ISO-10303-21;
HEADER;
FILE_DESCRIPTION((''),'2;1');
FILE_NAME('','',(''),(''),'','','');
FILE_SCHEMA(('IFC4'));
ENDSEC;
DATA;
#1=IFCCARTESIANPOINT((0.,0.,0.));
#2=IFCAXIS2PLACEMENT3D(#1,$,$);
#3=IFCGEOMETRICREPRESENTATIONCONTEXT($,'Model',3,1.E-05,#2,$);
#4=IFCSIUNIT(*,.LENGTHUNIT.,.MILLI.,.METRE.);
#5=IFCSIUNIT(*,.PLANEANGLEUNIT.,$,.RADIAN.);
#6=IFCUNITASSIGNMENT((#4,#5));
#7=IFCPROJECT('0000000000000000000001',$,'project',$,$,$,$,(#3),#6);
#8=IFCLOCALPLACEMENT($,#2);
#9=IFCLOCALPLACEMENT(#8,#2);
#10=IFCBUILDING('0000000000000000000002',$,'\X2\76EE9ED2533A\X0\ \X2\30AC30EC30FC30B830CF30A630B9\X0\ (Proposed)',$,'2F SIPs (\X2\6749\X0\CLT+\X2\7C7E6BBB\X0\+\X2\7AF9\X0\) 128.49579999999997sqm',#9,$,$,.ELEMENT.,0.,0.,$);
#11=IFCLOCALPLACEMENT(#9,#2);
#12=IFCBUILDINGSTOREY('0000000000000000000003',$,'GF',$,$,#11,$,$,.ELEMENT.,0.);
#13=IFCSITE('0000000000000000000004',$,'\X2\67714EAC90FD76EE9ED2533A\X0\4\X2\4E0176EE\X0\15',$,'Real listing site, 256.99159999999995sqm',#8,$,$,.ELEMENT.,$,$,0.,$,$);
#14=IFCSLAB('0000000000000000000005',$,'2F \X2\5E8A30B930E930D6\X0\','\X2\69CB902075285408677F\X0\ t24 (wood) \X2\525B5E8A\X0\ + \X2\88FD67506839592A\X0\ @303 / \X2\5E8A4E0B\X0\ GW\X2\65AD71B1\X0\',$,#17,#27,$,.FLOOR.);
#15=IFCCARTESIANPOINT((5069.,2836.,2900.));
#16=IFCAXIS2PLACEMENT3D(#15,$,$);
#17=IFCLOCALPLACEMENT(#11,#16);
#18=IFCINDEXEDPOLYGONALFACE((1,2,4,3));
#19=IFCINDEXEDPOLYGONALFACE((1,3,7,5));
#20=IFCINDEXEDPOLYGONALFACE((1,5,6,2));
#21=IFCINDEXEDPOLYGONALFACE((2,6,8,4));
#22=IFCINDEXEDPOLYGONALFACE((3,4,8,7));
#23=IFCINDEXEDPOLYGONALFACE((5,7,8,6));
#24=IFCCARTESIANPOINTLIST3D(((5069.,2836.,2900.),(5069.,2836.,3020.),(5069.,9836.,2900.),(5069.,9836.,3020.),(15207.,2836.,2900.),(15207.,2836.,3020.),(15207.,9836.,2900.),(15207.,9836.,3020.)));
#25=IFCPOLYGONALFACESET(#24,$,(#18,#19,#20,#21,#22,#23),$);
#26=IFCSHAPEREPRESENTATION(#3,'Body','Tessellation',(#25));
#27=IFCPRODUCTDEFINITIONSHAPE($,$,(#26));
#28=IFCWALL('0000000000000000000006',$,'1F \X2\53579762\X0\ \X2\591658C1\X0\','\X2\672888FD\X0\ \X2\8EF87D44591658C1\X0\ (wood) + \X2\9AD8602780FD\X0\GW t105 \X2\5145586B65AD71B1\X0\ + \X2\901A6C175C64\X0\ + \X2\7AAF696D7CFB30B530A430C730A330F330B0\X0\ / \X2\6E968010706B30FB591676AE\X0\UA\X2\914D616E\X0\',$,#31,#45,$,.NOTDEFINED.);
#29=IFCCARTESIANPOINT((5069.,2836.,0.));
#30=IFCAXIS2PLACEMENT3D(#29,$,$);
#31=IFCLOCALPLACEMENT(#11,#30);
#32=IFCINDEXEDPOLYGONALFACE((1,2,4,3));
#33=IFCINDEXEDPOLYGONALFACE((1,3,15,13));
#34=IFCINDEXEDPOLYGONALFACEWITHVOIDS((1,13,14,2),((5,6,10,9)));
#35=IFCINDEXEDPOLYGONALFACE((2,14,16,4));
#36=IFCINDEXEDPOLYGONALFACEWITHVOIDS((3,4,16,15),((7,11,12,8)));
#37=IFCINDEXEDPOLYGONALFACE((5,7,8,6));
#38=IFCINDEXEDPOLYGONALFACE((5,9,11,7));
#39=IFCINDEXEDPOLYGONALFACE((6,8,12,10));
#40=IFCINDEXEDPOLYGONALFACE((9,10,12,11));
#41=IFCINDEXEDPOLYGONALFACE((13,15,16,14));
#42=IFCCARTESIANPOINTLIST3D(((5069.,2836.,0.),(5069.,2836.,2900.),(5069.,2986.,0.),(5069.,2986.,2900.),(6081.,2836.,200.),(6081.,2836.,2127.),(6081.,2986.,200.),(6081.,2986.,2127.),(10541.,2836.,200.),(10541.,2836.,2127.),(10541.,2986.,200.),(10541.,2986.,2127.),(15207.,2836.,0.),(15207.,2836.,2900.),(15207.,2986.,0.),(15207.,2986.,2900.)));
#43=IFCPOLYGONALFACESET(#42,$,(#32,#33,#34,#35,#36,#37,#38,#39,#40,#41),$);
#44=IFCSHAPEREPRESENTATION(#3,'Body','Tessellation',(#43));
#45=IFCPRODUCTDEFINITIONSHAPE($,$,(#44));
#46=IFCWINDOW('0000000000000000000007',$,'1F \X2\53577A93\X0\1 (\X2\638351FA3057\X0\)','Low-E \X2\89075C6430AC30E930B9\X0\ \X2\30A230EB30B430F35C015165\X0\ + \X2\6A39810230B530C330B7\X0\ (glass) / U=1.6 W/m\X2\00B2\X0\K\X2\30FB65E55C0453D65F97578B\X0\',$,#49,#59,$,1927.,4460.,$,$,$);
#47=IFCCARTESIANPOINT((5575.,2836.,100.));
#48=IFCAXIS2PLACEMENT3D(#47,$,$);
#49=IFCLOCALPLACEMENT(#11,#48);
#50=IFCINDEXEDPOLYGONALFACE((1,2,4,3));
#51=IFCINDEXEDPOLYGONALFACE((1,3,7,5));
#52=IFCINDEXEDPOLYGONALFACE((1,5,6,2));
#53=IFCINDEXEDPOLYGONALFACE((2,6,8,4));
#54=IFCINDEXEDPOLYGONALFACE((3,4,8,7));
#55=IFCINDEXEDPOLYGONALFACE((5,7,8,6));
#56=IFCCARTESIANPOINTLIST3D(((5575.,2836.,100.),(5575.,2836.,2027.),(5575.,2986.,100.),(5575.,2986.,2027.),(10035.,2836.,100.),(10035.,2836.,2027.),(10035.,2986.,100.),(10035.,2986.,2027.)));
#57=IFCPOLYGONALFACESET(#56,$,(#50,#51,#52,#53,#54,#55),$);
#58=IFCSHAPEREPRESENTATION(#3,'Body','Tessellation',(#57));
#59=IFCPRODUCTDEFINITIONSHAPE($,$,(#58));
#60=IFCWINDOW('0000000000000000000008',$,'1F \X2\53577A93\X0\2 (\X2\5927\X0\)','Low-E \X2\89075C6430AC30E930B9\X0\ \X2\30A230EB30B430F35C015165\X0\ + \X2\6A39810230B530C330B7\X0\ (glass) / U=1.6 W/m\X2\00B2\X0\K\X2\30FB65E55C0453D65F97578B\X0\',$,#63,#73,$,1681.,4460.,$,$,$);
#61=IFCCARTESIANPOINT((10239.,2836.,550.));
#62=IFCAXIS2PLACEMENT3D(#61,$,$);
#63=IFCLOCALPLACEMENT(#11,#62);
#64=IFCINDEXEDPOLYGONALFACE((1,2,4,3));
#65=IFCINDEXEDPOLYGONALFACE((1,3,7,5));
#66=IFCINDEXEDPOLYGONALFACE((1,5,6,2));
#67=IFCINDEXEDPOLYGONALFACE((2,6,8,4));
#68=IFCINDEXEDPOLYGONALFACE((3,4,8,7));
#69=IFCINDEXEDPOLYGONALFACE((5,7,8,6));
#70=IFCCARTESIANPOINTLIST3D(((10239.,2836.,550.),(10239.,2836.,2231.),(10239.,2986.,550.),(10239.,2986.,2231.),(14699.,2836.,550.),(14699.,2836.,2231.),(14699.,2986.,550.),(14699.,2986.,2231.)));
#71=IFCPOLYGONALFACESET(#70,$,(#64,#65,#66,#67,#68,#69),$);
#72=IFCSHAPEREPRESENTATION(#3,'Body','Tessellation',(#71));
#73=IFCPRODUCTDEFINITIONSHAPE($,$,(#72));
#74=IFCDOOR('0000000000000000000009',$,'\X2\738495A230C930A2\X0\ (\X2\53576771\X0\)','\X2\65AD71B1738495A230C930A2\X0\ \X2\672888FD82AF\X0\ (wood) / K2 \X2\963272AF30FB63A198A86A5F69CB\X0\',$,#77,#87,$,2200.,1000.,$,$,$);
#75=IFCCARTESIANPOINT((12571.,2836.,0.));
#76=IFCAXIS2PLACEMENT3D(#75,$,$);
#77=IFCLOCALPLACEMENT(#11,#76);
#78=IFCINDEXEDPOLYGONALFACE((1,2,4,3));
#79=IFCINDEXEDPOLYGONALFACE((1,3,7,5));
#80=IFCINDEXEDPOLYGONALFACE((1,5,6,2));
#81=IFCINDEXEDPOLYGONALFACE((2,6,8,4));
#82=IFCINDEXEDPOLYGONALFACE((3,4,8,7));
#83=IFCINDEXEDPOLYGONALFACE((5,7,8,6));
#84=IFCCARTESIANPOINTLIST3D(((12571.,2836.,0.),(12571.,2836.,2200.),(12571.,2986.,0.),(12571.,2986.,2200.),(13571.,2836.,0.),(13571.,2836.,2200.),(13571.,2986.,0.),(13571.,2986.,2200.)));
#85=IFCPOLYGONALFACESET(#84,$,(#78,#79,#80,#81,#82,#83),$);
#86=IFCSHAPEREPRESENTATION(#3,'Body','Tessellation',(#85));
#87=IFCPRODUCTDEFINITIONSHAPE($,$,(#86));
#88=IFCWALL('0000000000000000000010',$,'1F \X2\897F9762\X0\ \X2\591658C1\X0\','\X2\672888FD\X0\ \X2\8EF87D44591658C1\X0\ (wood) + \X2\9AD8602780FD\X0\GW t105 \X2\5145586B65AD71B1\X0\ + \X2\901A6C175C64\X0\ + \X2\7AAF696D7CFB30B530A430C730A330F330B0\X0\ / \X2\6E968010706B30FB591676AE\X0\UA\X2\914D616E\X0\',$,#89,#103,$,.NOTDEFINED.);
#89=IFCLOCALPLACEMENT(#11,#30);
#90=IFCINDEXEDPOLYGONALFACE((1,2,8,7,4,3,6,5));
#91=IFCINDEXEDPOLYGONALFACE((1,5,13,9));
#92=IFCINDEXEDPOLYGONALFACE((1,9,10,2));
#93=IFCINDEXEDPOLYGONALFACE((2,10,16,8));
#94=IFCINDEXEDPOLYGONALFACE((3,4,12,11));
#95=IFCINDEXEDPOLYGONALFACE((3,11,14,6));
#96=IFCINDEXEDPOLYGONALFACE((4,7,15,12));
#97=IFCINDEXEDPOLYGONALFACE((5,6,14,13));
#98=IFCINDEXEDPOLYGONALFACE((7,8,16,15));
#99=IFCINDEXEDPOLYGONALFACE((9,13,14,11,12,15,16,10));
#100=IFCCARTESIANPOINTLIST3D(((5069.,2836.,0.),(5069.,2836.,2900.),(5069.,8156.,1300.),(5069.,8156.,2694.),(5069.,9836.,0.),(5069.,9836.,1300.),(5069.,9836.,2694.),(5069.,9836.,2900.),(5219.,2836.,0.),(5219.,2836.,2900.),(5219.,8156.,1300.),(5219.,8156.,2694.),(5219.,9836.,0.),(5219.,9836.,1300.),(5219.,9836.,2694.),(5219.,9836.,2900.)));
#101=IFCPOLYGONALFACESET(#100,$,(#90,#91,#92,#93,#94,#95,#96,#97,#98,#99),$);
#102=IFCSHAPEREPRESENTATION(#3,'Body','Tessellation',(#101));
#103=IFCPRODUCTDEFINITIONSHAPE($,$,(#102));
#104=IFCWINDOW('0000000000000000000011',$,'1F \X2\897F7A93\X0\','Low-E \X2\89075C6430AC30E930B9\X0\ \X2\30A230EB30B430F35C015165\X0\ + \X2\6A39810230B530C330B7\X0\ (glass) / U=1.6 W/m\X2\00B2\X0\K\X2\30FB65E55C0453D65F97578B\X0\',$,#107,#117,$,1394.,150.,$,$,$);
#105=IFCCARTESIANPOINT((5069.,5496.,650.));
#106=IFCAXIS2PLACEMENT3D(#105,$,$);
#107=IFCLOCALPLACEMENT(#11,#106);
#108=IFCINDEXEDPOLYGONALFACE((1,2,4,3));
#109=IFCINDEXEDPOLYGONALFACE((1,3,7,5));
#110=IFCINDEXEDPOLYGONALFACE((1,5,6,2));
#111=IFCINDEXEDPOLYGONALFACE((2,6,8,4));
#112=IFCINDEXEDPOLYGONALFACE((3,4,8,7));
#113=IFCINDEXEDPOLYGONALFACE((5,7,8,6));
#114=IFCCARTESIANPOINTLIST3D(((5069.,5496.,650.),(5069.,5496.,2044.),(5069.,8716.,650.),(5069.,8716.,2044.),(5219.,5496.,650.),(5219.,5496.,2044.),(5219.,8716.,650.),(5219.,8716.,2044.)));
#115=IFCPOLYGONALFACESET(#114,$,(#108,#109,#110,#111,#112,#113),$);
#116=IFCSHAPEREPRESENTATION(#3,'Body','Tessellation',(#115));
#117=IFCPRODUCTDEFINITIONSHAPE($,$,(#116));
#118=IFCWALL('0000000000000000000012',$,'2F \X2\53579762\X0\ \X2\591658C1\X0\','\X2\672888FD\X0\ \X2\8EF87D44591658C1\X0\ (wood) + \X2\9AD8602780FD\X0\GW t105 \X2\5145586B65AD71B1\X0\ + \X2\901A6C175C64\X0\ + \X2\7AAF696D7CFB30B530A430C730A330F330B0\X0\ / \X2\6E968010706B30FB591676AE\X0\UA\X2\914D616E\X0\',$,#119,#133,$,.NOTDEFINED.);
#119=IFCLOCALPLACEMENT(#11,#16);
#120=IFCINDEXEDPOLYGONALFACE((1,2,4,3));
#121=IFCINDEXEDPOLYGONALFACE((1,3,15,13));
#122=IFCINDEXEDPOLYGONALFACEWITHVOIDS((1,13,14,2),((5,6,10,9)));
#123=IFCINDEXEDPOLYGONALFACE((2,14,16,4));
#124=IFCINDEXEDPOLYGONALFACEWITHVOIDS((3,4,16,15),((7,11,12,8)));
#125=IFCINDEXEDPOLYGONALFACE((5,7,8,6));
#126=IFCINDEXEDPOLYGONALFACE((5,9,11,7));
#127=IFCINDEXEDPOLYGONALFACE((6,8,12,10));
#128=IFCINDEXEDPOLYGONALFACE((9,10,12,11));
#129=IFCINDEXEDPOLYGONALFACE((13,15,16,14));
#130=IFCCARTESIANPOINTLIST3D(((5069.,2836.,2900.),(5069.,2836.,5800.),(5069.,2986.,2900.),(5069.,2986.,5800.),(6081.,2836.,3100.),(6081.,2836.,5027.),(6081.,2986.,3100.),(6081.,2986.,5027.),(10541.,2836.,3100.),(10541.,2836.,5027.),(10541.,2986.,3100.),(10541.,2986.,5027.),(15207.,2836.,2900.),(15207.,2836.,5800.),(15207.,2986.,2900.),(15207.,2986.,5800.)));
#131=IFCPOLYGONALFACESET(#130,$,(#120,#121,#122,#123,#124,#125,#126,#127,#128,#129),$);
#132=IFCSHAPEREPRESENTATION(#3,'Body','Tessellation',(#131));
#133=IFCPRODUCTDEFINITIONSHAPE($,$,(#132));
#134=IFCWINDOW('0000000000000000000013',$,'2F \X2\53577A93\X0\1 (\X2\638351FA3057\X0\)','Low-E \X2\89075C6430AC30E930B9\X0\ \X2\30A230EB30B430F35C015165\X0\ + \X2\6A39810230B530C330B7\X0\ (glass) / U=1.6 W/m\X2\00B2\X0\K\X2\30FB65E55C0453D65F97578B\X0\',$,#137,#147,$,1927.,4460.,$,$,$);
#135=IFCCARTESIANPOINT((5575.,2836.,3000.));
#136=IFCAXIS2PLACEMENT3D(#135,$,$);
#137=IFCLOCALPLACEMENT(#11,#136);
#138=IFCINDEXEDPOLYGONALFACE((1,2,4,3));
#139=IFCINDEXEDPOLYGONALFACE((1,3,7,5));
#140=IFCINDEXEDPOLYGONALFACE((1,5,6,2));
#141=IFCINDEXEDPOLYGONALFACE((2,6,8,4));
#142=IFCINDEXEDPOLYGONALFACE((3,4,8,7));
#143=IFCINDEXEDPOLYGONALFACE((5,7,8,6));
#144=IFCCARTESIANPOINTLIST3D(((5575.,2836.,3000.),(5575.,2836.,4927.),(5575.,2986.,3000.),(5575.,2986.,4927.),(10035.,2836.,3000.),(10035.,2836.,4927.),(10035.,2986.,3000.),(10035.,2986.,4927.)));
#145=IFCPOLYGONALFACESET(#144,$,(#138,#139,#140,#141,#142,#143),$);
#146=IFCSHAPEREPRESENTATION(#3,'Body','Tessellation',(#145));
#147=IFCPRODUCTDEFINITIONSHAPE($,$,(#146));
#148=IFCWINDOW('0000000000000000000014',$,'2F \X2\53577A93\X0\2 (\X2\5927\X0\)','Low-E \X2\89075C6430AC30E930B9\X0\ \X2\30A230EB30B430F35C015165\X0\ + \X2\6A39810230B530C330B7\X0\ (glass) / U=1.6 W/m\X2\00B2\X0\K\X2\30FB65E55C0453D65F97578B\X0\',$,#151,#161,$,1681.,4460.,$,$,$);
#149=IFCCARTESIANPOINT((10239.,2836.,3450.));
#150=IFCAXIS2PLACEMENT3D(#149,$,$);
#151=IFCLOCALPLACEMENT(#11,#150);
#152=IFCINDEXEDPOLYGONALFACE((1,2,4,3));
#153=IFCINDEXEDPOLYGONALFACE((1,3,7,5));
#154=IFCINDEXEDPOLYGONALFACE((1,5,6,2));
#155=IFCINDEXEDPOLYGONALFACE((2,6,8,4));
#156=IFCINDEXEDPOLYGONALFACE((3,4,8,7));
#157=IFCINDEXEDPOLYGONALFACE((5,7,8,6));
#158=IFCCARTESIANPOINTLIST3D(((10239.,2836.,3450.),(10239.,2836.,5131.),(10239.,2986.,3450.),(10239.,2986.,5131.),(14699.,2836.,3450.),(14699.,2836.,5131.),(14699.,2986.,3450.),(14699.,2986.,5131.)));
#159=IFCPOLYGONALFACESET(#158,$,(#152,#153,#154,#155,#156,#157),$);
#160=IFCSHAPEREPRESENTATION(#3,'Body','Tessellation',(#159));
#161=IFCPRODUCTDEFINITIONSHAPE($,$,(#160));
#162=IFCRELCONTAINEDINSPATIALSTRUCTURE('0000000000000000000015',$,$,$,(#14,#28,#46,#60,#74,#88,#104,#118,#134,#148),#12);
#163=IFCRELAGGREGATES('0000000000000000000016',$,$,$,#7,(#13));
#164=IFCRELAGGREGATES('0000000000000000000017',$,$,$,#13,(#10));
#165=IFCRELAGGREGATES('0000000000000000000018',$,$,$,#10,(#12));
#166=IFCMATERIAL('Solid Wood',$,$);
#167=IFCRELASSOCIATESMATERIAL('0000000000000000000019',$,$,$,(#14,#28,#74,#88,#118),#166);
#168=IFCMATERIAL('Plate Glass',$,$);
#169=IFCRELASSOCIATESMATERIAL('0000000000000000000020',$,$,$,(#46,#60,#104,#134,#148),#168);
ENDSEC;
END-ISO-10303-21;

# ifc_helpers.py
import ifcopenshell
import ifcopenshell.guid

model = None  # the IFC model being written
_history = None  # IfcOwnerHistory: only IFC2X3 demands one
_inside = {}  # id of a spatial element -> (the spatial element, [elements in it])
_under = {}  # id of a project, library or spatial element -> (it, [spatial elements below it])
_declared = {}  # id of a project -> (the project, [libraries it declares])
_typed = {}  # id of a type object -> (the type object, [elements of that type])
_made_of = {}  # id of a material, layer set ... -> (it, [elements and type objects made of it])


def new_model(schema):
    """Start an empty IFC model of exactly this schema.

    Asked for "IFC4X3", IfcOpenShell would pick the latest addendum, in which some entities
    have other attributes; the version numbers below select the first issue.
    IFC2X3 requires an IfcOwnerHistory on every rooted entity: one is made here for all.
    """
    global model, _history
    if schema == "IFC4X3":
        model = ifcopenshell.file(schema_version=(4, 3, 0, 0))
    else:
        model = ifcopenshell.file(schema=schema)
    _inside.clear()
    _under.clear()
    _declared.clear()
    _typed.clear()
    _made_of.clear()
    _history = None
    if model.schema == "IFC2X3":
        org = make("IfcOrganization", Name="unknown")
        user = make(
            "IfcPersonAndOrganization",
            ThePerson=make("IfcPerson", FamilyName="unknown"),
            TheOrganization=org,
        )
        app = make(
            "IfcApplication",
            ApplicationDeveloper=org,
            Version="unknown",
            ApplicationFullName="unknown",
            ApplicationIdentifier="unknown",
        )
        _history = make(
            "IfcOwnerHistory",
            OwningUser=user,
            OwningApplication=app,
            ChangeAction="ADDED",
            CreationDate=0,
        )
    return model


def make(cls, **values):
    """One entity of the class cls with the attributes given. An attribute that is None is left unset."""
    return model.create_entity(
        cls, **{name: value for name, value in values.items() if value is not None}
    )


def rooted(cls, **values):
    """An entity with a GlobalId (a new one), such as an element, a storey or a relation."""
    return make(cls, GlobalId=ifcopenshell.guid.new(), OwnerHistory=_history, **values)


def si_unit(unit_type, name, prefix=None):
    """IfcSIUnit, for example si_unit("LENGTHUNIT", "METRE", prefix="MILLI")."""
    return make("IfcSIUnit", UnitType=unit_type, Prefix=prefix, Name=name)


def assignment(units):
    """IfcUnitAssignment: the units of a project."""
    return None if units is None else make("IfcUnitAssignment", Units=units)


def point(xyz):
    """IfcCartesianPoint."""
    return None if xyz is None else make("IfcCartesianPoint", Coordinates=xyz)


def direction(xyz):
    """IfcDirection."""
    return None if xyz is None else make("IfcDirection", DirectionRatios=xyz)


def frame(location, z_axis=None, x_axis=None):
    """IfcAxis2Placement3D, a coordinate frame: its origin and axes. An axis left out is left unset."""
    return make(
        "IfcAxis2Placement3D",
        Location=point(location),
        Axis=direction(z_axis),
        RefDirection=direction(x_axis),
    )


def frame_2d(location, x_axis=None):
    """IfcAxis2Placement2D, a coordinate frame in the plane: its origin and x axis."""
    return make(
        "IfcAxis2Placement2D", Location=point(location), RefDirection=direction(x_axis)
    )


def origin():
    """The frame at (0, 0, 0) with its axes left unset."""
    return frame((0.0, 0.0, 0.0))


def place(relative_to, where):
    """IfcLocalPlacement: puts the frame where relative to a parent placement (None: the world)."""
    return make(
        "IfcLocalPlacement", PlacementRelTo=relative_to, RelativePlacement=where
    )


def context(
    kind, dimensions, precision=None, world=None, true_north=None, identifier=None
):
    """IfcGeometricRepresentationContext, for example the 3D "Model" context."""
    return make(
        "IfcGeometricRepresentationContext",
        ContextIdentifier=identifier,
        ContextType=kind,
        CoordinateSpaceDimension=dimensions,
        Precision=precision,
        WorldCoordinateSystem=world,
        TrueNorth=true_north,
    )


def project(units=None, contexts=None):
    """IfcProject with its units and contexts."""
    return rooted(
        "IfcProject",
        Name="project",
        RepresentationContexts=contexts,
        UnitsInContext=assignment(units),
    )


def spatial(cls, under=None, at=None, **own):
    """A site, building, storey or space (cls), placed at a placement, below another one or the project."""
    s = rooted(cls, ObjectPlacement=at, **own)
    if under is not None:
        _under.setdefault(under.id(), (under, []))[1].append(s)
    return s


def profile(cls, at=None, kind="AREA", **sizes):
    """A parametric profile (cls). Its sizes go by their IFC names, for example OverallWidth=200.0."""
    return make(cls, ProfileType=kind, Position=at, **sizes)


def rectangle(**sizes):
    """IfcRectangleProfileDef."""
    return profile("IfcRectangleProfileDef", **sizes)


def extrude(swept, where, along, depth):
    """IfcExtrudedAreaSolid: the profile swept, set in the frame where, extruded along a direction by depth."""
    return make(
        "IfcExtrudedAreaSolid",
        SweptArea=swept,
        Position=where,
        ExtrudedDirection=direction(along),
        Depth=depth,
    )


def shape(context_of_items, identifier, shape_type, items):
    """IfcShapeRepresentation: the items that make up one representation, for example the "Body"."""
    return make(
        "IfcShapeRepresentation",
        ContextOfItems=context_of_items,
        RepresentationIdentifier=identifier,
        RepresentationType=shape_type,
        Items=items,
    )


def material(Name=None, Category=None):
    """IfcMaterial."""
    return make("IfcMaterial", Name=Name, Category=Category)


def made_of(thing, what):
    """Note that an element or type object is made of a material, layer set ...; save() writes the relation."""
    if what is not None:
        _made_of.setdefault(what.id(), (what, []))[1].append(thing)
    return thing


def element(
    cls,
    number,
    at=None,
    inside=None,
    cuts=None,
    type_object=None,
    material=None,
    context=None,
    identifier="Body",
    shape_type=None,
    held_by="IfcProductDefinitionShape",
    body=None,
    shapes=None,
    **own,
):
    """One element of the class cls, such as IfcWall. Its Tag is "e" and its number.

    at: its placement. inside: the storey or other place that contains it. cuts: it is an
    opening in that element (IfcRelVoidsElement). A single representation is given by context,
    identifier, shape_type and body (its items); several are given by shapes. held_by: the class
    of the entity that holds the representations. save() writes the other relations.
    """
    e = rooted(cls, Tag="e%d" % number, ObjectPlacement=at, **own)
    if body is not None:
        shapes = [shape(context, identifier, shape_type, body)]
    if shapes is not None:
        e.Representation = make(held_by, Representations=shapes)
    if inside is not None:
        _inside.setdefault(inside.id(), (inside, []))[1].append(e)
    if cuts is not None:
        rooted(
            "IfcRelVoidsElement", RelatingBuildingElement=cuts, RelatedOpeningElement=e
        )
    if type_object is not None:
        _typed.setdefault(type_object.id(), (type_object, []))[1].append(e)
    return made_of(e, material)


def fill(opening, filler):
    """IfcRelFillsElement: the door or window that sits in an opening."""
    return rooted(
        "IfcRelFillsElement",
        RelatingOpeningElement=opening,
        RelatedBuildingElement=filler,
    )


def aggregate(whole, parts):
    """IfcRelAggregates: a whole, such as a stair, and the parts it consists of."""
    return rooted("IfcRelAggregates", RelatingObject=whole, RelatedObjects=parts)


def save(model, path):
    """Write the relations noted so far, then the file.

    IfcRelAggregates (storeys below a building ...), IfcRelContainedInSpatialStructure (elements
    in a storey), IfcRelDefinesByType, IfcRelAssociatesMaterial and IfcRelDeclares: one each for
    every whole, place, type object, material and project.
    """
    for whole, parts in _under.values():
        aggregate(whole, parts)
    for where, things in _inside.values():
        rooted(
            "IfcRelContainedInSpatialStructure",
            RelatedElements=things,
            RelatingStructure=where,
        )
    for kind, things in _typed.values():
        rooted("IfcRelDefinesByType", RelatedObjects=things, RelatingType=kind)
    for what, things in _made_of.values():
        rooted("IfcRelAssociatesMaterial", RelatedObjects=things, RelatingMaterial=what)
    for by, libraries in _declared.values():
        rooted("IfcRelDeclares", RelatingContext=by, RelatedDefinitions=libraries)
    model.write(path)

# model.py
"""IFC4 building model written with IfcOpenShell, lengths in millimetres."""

from ifc_helpers import new_model, si_unit, frame, frame_2d, origin, place, context, project, spatial, rectangle, extrude, material, element, fill, save


model = new_model("IFC4")

# Units and contexts
model_context = context("Model", 3, precision=1e-05, world=origin())
ifc_project = project(units=[si_unit("LENGTHUNIT", "METRE", prefix="MILLI"), si_unit("PLANEANGLEUNIT", "RADIAN")], contexts=[model_context])

# Site, building, storey
site_placement = place(None, origin())
site = spatial("IfcSite", under=ifc_project, at=site_placement, Name="東京都目黒区4丁目15", ObjectType="Real listing site, 256.99159999999995sqm", CompositionType="ELEMENT", RefElevation=0.0)
building_placement = place(site_placement, origin())
building = spatial("IfcBuilding", under=site, at=building_placement, Name="目黒区 ガレージハウス (Proposed)", ObjectType="2F SIPs (杉CLT+籾殻+竹) 128.49579999999997sqm", CompositionType="ELEMENT", ElevationOfRefHeight=0.0, ElevationOfTerrain=0.0)
storey_placement = place(building_placement, origin())
storey = spatial("IfcBuildingStorey", under=building, at=storey_placement, Name="GF", CompositionType="ELEMENT", Elevation=0.0)

# Slab
ifc_material_1 = material(Name="Solid Wood")
slab_1_placement = place(storey_placement, frame((5069.0, 2836.0, 2900.0)))
element("IfcSlab", 1, at=slab_1_placement, inside=storey, material=ifc_material_1, Name="2F 床スラブ", Description="構造用合板 t24 (wood) 剛床 + 製材根太 @303 / 床下 GW断熱", PredefinedType="FLOOR", context=model_context, shape_type="SweptSolid", body=[
    extrude(rectangle(XDim=10138.0, YDim=7000.0, at=frame_2d((5069.0, 3500.0))), frame((5069.0, 2836.0, 2900.0)), (0.0, 0.0, 1.0), 120.0),
])

# Wall, openings, windows, door
wall_1_placement = place(storey_placement, frame((5069.0, 2836.0, 0.0)))
wall_1 = element("IfcWall", 2, at=wall_1_placement, inside=storey, material=ifc_material_1, Name="1F 南面 外壁", Description="木製 軸組外壁 (wood) + 高性能GW t105 充填断熱 + 通気層 + 窯業系サイディング / 準耐火・外皮UA配慮", PredefinedType="NOTDEFINED", context=model_context, shape_type="SweptSolid", body=[
    extrude(rectangle(XDim=10138.0, YDim=150.0, at=frame_2d((5069.0, 75.0))), frame((5069.0, 2836.0, 0.0)), (0.0, 0.0, 1.0), 2900.0),
])
opening_1_placement = place(storey_placement, frame((5575.0, 2836.0, 100.0)))
opening_1 = element("IfcOpeningElement", 3, at=opening_1_placement, cuts=wall_1, PredefinedType="NOTDEFINED", context=model_context, shape_type="SweptSolid", body=[
    extrude(rectangle(XDim=4460.0, YDim=150.0, at=frame_2d((2230.0, 75.0))), frame((5575.0, 2836.0, 100.0)), (0.0, 0.0, 1.0), 1927.0),
])
opening_2_placement = place(storey_placement, frame((10239.0, 2836.0, 550.0)))
opening_2 = element("IfcOpeningElement", 4, at=opening_2_placement, cuts=wall_1, PredefinedType="NOTDEFINED", context=model_context, shape_type="SweptSolid", body=[
    extrude(rectangle(XDim=4460.0, YDim=150.0, at=frame_2d((2230.0, 75.0))), frame((10239.0, 2836.0, 550.0)), (0.0, 0.0, 1.0), 1681.0),
])
opening_3_placement = place(storey_placement, frame((12571.0, 2836.0, 0.0)))
opening_3 = element("IfcOpeningElement", 5, at=opening_3_placement, cuts=wall_1, PredefinedType="NOTDEFINED", context=model_context, shape_type="SweptSolid", body=[
    extrude(rectangle(XDim=1000.0, YDim=150.0, at=frame_2d((500.0, 75.0))), frame((12571.0, 2836.0, 0.0)), (0.0, 0.0, 1.0), 2200.0),
])
ifc_material_2 = material(Name="Plate Glass")
window_1_placement = place(storey_placement, frame((5575.0, 2836.0, 100.0)))
window_1 = element("IfcWindow", 6, at=window_1_placement, inside=storey, material=ifc_material_2, Name="1F 南窓1 (掃出し)", Description="Low-E 複層ガラス アルゴン封入 + 樹脂サッシ (glass) / U=1.6 W/m²K・日射取得型", OverallHeight=1927.0, OverallWidth=4460.0, context=model_context, shape_type="SweptSolid", body=[
    extrude(rectangle(XDim=4460.0, YDim=150.0, at=frame_2d((2230.0, 75.0))), frame((5575.0, 2836.0, 100.0)), (0.0, 0.0, 1.0), 1927.0),
])
fill(opening_1, window_1)
window_2_placement = place(storey_placement, frame((10239.0, 2836.0, 550.0)))
window_2 = element("IfcWindow", 7, at=window_2_placement, inside=storey, material=ifc_material_2, Name="1F 南窓2 (大)", Description="Low-E 複層ガラス アルゴン封入 + 樹脂サッシ (glass) / U=1.6 W/m²K・日射取得型", OverallHeight=1681.0, OverallWidth=4460.0, context=model_context, shape_type="SweptSolid", body=[
    extrude(rectangle(XDim=4460.0, YDim=150.0, at=frame_2d((2230.0, 75.0))), frame((10239.0, 2836.0, 550.0)), (0.0, 0.0, 1.0), 1681.0),
])
fill(opening_2, window_2)
door_placement = place(storey_placement, frame((12571.0, 2836.0, 0.0)))
door = element("IfcDoor", 8, at=door_placement, inside=storey, material=ifc_material_1, Name="玄関ドア (南東)", Description="断熱玄関ドア 木製芯 (wood) / K2 防犯・採風機構", OverallHeight=2200.0, OverallWidth=1000.0, context=model_context, shape_type="SweptSolid", body=[
    extrude(rectangle(XDim=1000.0, YDim=150.0, at=frame_2d((500.0, 75.0))), frame((12571.0, 2836.0, 0.0)), (0.0, 0.0, 1.0), 2200.0),
])
fill(opening_3, door)

# Wall, opening, window
wall_2_placement = place(storey_placement, frame((5069.0, 2836.0, 0.0)))
wall_2 = element("IfcWall", 9, at=wall_2_placement, inside=storey, material=ifc_material_1, Name="1F 西面 外壁", Description="木製 軸組外壁 (wood) + 高性能GW t105 充填断熱 + 通気層 + 窯業系サイディング / 準耐火・外皮UA配慮", PredefinedType="NOTDEFINED", context=model_context, shape_type="SweptSolid", body=[
    extrude(rectangle(XDim=150.0, YDim=7000.0, at=frame_2d((75.0, 3500.0))), frame((5069.0, 2836.0, 0.0)), (0.0, 0.0, 1.0), 2900.0),
])
opening_4_placement = place(storey_placement, frame((5069.0, 5496.0, 650.0)))
opening_4 = element("IfcOpeningElement", 10, at=opening_4_placement, cuts=wall_2, PredefinedType="NOTDEFINED", context=model_context, shape_type="SweptSolid", body=[
    extrude(rectangle(XDim=150.0, YDim=3220.0, at=frame_2d((75.0, 1610.0))), frame((5069.0, 5496.0, 650.0)), (0.0, 0.0, 1.0), 1394.0),
])
window_3_placement = place(storey_placement, frame((5069.0, 5496.0, 650.0)))
window_3 = element("IfcWindow", 11, at=window_3_placement, inside=storey, material=ifc_material_2, Name="1F 西窓", Description="Low-E 複層ガラス アルゴン封入 + 樹脂サッシ (glass) / U=1.6 W/m²K・日射取得型", OverallHeight=1394.0, OverallWidth=150.0, context=model_context, shape_type="SweptSolid", body=[
    extrude(rectangle(XDim=150.0, YDim=3220.0, at=frame_2d((75.0, 1610.0))), frame((5069.0, 5496.0, 650.0)), (0.0, 0.0, 1.0), 1394.0),
])
fill(opening_4, window_3)

# Wall, openings, windows
wall_3_placement = place(storey_placement, frame((5069.0, 2836.0, 2900.0)))
wall_3 = element("IfcWall", 12, at=wall_3_placement, inside=storey, material=ifc_material_1, Name="2F 南面 外壁", Description="木製 軸組外壁 (wood) + 高性能GW t105 充填断熱 + 通気層 + 窯業系サイディング / 準耐火・外皮UA配慮", PredefinedType="NOTDEFINED", context=model_context, shape_type="SweptSolid", body=[
    extrude(rectangle(XDim=10138.0, YDim=150.0, at=frame_2d((5069.0, 75.0))), frame((5069.0, 2836.0, 2900.0)), (0.0, 0.0, 1.0), 2900.0),
])
opening_5_placement = place(storey_placement, frame((5575.0, 2836.0, 3000.0)))
opening_5 = element("IfcOpeningElement", 13, at=opening_5_placement, cuts=wall_3, PredefinedType="NOTDEFINED", context=model_context, shape_type="SweptSolid", body=[
    extrude(rectangle(XDim=4460.0, YDim=150.0, at=frame_2d((2230.0, 75.0))), frame((5575.0, 2836.0, 3000.0)), (0.0, 0.0, 1.0), 1927.0),
])
opening_6_placement = place(storey_placement, frame((10239.0, 2836.0, 3450.0)))
opening_6 = element("IfcOpeningElement", 14, at=opening_6_placement, cuts=wall_3, PredefinedType="NOTDEFINED", context=model_context, shape_type="SweptSolid", body=[
    extrude(rectangle(XDim=4460.0, YDim=150.0, at=frame_2d((2230.0, 75.0))), frame((10239.0, 2836.0, 3450.0)), (0.0, 0.0, 1.0), 1681.0),
])
window_4_placement = place(storey_placement, frame((5575.0, 2836.0, 3000.0)))
window_4 = element("IfcWindow", 15, at=window_4_placement, inside=storey, material=ifc_material_2, Name="2F 南窓1 (掃出し)", Description="Low-E 複層ガラス アルゴン封入 + 樹脂サッシ (glass) / U=1.6 W/m²K・日射取得型", OverallHeight=1927.0, OverallWidth=4460.0, context=model_context, shape_type="SweptSolid", body=[
    extrude(rectangle(XDim=4460.0, YDim=150.0, at=frame_2d((2230.0, 75.0))), frame((5575.0, 2836.0, 3000.0)), (0.0, 0.0, 1.0), 1927.0),
])
fill(opening_5, window_4)
window_5_placement = place(storey_placement, frame((10239.0, 2836.0, 3450.0)))
window_5 = element("IfcWindow", 16, at=window_5_placement, inside=storey, material=ifc_material_2, Name="2F 南窓2 (大)", Description="Low-E 複層ガラス アルゴン封入 + 樹脂サッシ (glass) / U=1.6 W/m²K・日射取得型", OverallHeight=1681.0, OverallWidth=4460.0, context=model_context, shape_type="SweptSolid", body=[
    extrude(rectangle(XDim=4460.0, YDim=150.0, at=frame_2d((2230.0, 75.0))), frame((10239.0, 2836.0, 3450.0)), (0.0, 0.0, 1.0), 1681.0),
])
fill(opening_6, window_5)

save(model, "model.ifc")
